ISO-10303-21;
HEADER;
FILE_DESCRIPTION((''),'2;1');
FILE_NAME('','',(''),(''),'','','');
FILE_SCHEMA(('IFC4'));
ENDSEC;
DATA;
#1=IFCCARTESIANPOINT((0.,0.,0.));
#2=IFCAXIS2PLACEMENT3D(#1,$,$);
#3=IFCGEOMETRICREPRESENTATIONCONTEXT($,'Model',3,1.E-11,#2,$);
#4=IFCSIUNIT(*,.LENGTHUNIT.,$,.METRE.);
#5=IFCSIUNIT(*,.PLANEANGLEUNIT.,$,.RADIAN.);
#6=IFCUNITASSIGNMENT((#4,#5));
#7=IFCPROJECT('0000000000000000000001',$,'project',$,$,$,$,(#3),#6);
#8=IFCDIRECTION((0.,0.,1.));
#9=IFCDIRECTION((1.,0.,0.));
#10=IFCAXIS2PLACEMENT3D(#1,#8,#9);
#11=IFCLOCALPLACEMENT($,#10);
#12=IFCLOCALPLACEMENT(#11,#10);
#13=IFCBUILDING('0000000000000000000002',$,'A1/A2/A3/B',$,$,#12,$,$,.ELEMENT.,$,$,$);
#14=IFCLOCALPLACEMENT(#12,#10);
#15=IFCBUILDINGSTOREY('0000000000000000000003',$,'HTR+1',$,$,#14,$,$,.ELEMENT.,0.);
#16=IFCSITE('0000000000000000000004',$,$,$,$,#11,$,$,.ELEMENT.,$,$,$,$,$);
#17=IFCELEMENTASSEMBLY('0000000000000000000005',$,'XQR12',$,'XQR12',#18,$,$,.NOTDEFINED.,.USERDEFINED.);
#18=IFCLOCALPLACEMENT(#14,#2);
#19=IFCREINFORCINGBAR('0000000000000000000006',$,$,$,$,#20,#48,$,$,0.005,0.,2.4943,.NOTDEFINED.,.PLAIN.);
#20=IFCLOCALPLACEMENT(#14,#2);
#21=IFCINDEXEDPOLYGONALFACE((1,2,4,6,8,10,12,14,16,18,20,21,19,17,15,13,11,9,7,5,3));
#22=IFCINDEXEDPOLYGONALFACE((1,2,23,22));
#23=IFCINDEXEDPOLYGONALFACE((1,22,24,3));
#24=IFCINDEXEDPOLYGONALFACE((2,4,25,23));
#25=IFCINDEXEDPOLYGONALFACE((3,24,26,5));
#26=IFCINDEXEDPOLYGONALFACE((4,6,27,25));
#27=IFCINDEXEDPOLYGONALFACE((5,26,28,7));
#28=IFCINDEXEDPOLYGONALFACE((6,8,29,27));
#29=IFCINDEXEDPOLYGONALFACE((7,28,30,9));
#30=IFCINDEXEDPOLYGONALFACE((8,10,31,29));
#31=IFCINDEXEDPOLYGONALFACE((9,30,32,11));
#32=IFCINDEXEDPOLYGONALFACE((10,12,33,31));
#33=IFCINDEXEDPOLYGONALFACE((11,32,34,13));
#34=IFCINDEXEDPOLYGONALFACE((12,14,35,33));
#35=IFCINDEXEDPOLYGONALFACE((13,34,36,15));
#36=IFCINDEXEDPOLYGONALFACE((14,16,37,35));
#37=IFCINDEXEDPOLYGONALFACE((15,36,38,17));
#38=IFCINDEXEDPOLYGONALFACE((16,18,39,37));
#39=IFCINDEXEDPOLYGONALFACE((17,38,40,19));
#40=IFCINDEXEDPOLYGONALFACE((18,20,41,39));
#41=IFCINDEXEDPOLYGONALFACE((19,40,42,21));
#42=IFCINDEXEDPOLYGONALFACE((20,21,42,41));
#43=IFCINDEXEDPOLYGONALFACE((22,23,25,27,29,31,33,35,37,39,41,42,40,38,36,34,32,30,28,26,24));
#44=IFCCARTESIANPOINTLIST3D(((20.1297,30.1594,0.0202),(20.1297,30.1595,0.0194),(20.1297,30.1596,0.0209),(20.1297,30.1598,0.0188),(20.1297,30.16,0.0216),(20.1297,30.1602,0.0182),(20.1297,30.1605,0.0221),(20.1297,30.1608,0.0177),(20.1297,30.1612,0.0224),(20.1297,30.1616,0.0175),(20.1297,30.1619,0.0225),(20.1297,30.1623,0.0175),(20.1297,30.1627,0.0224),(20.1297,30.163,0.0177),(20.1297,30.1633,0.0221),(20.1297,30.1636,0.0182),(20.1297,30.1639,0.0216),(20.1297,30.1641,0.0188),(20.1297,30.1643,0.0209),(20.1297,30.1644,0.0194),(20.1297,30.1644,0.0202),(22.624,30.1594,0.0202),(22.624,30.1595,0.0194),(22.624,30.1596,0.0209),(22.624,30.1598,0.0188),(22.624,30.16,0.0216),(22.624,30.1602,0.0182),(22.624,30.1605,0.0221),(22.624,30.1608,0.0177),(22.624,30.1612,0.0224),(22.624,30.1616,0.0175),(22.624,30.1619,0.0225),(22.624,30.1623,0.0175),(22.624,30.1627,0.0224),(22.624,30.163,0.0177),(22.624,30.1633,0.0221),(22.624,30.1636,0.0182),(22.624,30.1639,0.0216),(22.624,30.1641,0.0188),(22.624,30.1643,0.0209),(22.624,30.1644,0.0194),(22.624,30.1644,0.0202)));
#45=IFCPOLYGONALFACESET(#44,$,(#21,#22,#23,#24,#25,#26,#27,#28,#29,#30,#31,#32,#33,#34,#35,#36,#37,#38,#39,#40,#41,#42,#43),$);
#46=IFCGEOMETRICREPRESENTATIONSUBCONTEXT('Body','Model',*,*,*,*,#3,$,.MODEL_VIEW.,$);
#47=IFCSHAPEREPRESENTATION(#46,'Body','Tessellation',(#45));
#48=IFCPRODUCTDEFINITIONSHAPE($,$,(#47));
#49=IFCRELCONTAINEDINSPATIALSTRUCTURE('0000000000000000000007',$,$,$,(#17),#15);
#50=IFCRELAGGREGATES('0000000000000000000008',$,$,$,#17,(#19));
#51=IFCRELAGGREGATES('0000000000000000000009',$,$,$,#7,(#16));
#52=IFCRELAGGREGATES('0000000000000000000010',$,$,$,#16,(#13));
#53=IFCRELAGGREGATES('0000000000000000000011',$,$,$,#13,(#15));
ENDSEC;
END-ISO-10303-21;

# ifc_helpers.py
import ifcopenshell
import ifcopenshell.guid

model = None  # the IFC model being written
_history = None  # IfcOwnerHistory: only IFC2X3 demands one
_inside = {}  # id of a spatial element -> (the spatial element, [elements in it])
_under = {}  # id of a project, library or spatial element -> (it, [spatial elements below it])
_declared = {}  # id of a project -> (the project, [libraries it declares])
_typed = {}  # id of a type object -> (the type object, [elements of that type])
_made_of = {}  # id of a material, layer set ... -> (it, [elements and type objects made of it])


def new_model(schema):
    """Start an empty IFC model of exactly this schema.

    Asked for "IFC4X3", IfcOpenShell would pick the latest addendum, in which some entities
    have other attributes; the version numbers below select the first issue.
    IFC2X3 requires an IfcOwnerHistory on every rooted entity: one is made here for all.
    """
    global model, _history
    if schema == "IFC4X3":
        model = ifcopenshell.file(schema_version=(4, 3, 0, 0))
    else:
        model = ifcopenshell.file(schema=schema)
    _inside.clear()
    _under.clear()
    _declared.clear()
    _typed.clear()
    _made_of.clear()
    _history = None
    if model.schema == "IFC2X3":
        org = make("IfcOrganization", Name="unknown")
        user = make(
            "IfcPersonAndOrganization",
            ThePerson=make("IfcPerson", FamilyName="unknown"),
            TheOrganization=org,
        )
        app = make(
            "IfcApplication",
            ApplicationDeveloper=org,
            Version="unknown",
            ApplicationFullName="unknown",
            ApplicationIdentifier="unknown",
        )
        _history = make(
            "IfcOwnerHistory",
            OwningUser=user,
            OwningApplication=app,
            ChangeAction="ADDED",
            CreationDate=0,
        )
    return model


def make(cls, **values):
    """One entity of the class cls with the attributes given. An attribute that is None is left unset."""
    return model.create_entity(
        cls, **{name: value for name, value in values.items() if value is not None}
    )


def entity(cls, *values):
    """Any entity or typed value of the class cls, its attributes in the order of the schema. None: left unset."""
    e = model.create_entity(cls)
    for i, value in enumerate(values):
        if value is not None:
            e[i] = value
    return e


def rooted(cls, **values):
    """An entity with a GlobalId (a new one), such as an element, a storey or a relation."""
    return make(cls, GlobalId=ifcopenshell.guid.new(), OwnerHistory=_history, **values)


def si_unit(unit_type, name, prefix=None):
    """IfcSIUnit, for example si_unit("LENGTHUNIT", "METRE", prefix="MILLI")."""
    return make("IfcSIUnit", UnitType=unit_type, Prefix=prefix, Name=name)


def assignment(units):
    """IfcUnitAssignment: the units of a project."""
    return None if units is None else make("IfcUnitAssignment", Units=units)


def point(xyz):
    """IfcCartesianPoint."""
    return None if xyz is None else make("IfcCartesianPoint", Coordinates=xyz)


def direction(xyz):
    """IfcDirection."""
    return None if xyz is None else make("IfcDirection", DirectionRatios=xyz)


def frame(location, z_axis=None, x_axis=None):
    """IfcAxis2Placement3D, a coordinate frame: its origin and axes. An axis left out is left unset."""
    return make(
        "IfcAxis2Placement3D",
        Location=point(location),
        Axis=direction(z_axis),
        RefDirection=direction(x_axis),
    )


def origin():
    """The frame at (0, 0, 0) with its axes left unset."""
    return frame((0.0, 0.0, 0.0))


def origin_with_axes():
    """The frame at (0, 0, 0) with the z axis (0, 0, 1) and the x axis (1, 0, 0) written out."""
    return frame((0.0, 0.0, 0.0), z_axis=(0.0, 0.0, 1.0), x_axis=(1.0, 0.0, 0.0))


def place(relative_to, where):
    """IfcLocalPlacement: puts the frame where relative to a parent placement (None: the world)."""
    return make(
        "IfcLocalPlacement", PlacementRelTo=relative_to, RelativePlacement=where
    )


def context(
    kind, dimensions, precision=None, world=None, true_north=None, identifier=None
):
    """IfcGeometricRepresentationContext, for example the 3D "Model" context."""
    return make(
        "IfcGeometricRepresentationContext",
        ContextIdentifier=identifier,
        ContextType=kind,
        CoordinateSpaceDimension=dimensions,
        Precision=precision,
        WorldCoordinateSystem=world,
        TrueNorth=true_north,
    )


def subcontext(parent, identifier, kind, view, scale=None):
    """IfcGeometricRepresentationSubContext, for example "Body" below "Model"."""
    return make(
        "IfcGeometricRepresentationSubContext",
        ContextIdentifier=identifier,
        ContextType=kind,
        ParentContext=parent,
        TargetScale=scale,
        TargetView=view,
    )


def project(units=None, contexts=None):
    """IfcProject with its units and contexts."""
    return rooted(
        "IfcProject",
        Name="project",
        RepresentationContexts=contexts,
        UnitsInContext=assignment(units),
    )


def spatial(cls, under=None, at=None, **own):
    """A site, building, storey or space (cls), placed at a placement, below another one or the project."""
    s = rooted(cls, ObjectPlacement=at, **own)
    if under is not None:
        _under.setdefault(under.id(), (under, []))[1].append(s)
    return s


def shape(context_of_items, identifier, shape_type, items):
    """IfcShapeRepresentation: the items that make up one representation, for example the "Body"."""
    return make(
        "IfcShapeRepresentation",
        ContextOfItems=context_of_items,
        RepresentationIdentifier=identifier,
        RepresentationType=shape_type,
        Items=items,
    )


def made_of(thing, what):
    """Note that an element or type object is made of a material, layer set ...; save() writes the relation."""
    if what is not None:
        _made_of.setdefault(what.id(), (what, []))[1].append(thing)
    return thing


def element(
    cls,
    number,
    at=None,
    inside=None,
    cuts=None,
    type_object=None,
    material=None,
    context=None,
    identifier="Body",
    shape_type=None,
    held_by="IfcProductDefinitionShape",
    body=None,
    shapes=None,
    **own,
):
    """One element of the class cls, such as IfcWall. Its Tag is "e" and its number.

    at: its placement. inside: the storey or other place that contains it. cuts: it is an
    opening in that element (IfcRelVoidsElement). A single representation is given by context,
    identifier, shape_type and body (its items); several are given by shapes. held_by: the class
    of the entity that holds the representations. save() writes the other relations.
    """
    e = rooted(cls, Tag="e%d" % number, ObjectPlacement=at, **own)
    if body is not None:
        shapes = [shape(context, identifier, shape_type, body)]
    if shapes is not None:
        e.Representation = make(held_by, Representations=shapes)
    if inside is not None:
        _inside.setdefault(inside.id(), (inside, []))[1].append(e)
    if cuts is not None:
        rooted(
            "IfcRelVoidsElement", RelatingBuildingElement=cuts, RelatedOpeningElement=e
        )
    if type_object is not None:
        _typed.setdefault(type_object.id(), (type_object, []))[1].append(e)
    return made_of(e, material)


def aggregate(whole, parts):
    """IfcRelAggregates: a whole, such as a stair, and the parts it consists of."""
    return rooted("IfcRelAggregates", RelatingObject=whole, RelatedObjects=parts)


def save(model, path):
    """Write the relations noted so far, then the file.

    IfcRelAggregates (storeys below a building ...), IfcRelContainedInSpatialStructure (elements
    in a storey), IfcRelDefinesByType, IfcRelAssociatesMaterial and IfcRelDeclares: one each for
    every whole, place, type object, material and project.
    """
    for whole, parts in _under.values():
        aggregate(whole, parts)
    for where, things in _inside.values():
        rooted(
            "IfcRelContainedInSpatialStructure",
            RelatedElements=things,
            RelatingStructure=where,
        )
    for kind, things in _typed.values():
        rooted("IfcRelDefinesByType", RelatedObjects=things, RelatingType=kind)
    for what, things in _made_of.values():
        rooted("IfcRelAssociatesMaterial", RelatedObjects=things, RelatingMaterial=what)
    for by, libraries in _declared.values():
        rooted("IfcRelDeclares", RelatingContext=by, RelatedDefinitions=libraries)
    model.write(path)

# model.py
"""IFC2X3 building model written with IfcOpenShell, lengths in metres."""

from ifc_helpers import new_model, entity, si_unit, origin, origin_with_axes, place, context, subcontext, project, spatial, shape, element, aggregate, save


model = new_model("IFC2X3")

# Units and contexts
model_context = context("Model", 3, precision=1e-11, world=origin())
body_context = subcontext(model_context, "Body", "Model", "MODEL_VIEW")
ifc_project = project(units=[si_unit("LENGTHUNIT", "METRE"), si_unit("PLANEANGLEUNIT", "RADIAN")], contexts=[model_context])

# Site, building, storey
site_placement = place(None, origin_with_axes())
site = spatial("IfcSite", under=ifc_project, at=site_placement, CompositionType="ELEMENT")
building_placement = place(site_placement, origin_with_axes())
building = spatial("IfcBuilding", under=site, at=building_placement, Name="A1/A2/A3/B", CompositionType="ELEMENT")
storey_placement = place(building_placement, origin_with_axes())
storey = spatial("IfcBuildingStorey", under=building, at=storey_placement, Name="HTR+1", CompositionType="ELEMENT", Elevation=0.0)

# Element assembly, reinforcing bar
assembly_1_placement = place(storey_placement, origin_with_axes())
assembly_1 = element("IfcElementAssembly", 1, at=assembly_1_placement, inside=storey, Name="XQR12", ObjectType="XQR12", AssemblyPlace="NOTDEFINED", PredefinedType="USERDEFINED")
reinforcing_bar_1_placement = place(assembly_1_placement, origin_with_axes())
reinforcing_bar_1 = element("IfcReinforcingBar", 2, at=reinforcing_bar_1_placement, BarLength=2.4943, BarRole="NOTDEFINED", BarSurface="PLAIN", CrossSectionArea=0.0, NominalDiameter=0.005, shapes=[
    shape(body_context, "Body", "AdvancedSweptSolid", [entity("IfcSweptDiskSolid", entity("IfcPolyline", [entity("IfcCartesianPoint", [20.1297, 30.1619, 0.02]), entity("IfcCartesianPoint", [22.624, 30.1619, 0.02])]), 0.0025, None, 0.0, 2.4943)]),
    shape(body_context, "Body", "AdvancedSweptSolid", [entity("IfcSweptDiskSolid", entity("IfcPolyline", [entity("IfcCartesianPoint", [20.1297, 30.1619, 0.02]), entity("IfcCartesianPoint", [22.624, 30.1619, 0.02])]), 0.0025, None, 0.0, 2.4943)]),
])
aggregate(assembly_1, [reinforcing_bar_1])

save(model, "model.ifc")
